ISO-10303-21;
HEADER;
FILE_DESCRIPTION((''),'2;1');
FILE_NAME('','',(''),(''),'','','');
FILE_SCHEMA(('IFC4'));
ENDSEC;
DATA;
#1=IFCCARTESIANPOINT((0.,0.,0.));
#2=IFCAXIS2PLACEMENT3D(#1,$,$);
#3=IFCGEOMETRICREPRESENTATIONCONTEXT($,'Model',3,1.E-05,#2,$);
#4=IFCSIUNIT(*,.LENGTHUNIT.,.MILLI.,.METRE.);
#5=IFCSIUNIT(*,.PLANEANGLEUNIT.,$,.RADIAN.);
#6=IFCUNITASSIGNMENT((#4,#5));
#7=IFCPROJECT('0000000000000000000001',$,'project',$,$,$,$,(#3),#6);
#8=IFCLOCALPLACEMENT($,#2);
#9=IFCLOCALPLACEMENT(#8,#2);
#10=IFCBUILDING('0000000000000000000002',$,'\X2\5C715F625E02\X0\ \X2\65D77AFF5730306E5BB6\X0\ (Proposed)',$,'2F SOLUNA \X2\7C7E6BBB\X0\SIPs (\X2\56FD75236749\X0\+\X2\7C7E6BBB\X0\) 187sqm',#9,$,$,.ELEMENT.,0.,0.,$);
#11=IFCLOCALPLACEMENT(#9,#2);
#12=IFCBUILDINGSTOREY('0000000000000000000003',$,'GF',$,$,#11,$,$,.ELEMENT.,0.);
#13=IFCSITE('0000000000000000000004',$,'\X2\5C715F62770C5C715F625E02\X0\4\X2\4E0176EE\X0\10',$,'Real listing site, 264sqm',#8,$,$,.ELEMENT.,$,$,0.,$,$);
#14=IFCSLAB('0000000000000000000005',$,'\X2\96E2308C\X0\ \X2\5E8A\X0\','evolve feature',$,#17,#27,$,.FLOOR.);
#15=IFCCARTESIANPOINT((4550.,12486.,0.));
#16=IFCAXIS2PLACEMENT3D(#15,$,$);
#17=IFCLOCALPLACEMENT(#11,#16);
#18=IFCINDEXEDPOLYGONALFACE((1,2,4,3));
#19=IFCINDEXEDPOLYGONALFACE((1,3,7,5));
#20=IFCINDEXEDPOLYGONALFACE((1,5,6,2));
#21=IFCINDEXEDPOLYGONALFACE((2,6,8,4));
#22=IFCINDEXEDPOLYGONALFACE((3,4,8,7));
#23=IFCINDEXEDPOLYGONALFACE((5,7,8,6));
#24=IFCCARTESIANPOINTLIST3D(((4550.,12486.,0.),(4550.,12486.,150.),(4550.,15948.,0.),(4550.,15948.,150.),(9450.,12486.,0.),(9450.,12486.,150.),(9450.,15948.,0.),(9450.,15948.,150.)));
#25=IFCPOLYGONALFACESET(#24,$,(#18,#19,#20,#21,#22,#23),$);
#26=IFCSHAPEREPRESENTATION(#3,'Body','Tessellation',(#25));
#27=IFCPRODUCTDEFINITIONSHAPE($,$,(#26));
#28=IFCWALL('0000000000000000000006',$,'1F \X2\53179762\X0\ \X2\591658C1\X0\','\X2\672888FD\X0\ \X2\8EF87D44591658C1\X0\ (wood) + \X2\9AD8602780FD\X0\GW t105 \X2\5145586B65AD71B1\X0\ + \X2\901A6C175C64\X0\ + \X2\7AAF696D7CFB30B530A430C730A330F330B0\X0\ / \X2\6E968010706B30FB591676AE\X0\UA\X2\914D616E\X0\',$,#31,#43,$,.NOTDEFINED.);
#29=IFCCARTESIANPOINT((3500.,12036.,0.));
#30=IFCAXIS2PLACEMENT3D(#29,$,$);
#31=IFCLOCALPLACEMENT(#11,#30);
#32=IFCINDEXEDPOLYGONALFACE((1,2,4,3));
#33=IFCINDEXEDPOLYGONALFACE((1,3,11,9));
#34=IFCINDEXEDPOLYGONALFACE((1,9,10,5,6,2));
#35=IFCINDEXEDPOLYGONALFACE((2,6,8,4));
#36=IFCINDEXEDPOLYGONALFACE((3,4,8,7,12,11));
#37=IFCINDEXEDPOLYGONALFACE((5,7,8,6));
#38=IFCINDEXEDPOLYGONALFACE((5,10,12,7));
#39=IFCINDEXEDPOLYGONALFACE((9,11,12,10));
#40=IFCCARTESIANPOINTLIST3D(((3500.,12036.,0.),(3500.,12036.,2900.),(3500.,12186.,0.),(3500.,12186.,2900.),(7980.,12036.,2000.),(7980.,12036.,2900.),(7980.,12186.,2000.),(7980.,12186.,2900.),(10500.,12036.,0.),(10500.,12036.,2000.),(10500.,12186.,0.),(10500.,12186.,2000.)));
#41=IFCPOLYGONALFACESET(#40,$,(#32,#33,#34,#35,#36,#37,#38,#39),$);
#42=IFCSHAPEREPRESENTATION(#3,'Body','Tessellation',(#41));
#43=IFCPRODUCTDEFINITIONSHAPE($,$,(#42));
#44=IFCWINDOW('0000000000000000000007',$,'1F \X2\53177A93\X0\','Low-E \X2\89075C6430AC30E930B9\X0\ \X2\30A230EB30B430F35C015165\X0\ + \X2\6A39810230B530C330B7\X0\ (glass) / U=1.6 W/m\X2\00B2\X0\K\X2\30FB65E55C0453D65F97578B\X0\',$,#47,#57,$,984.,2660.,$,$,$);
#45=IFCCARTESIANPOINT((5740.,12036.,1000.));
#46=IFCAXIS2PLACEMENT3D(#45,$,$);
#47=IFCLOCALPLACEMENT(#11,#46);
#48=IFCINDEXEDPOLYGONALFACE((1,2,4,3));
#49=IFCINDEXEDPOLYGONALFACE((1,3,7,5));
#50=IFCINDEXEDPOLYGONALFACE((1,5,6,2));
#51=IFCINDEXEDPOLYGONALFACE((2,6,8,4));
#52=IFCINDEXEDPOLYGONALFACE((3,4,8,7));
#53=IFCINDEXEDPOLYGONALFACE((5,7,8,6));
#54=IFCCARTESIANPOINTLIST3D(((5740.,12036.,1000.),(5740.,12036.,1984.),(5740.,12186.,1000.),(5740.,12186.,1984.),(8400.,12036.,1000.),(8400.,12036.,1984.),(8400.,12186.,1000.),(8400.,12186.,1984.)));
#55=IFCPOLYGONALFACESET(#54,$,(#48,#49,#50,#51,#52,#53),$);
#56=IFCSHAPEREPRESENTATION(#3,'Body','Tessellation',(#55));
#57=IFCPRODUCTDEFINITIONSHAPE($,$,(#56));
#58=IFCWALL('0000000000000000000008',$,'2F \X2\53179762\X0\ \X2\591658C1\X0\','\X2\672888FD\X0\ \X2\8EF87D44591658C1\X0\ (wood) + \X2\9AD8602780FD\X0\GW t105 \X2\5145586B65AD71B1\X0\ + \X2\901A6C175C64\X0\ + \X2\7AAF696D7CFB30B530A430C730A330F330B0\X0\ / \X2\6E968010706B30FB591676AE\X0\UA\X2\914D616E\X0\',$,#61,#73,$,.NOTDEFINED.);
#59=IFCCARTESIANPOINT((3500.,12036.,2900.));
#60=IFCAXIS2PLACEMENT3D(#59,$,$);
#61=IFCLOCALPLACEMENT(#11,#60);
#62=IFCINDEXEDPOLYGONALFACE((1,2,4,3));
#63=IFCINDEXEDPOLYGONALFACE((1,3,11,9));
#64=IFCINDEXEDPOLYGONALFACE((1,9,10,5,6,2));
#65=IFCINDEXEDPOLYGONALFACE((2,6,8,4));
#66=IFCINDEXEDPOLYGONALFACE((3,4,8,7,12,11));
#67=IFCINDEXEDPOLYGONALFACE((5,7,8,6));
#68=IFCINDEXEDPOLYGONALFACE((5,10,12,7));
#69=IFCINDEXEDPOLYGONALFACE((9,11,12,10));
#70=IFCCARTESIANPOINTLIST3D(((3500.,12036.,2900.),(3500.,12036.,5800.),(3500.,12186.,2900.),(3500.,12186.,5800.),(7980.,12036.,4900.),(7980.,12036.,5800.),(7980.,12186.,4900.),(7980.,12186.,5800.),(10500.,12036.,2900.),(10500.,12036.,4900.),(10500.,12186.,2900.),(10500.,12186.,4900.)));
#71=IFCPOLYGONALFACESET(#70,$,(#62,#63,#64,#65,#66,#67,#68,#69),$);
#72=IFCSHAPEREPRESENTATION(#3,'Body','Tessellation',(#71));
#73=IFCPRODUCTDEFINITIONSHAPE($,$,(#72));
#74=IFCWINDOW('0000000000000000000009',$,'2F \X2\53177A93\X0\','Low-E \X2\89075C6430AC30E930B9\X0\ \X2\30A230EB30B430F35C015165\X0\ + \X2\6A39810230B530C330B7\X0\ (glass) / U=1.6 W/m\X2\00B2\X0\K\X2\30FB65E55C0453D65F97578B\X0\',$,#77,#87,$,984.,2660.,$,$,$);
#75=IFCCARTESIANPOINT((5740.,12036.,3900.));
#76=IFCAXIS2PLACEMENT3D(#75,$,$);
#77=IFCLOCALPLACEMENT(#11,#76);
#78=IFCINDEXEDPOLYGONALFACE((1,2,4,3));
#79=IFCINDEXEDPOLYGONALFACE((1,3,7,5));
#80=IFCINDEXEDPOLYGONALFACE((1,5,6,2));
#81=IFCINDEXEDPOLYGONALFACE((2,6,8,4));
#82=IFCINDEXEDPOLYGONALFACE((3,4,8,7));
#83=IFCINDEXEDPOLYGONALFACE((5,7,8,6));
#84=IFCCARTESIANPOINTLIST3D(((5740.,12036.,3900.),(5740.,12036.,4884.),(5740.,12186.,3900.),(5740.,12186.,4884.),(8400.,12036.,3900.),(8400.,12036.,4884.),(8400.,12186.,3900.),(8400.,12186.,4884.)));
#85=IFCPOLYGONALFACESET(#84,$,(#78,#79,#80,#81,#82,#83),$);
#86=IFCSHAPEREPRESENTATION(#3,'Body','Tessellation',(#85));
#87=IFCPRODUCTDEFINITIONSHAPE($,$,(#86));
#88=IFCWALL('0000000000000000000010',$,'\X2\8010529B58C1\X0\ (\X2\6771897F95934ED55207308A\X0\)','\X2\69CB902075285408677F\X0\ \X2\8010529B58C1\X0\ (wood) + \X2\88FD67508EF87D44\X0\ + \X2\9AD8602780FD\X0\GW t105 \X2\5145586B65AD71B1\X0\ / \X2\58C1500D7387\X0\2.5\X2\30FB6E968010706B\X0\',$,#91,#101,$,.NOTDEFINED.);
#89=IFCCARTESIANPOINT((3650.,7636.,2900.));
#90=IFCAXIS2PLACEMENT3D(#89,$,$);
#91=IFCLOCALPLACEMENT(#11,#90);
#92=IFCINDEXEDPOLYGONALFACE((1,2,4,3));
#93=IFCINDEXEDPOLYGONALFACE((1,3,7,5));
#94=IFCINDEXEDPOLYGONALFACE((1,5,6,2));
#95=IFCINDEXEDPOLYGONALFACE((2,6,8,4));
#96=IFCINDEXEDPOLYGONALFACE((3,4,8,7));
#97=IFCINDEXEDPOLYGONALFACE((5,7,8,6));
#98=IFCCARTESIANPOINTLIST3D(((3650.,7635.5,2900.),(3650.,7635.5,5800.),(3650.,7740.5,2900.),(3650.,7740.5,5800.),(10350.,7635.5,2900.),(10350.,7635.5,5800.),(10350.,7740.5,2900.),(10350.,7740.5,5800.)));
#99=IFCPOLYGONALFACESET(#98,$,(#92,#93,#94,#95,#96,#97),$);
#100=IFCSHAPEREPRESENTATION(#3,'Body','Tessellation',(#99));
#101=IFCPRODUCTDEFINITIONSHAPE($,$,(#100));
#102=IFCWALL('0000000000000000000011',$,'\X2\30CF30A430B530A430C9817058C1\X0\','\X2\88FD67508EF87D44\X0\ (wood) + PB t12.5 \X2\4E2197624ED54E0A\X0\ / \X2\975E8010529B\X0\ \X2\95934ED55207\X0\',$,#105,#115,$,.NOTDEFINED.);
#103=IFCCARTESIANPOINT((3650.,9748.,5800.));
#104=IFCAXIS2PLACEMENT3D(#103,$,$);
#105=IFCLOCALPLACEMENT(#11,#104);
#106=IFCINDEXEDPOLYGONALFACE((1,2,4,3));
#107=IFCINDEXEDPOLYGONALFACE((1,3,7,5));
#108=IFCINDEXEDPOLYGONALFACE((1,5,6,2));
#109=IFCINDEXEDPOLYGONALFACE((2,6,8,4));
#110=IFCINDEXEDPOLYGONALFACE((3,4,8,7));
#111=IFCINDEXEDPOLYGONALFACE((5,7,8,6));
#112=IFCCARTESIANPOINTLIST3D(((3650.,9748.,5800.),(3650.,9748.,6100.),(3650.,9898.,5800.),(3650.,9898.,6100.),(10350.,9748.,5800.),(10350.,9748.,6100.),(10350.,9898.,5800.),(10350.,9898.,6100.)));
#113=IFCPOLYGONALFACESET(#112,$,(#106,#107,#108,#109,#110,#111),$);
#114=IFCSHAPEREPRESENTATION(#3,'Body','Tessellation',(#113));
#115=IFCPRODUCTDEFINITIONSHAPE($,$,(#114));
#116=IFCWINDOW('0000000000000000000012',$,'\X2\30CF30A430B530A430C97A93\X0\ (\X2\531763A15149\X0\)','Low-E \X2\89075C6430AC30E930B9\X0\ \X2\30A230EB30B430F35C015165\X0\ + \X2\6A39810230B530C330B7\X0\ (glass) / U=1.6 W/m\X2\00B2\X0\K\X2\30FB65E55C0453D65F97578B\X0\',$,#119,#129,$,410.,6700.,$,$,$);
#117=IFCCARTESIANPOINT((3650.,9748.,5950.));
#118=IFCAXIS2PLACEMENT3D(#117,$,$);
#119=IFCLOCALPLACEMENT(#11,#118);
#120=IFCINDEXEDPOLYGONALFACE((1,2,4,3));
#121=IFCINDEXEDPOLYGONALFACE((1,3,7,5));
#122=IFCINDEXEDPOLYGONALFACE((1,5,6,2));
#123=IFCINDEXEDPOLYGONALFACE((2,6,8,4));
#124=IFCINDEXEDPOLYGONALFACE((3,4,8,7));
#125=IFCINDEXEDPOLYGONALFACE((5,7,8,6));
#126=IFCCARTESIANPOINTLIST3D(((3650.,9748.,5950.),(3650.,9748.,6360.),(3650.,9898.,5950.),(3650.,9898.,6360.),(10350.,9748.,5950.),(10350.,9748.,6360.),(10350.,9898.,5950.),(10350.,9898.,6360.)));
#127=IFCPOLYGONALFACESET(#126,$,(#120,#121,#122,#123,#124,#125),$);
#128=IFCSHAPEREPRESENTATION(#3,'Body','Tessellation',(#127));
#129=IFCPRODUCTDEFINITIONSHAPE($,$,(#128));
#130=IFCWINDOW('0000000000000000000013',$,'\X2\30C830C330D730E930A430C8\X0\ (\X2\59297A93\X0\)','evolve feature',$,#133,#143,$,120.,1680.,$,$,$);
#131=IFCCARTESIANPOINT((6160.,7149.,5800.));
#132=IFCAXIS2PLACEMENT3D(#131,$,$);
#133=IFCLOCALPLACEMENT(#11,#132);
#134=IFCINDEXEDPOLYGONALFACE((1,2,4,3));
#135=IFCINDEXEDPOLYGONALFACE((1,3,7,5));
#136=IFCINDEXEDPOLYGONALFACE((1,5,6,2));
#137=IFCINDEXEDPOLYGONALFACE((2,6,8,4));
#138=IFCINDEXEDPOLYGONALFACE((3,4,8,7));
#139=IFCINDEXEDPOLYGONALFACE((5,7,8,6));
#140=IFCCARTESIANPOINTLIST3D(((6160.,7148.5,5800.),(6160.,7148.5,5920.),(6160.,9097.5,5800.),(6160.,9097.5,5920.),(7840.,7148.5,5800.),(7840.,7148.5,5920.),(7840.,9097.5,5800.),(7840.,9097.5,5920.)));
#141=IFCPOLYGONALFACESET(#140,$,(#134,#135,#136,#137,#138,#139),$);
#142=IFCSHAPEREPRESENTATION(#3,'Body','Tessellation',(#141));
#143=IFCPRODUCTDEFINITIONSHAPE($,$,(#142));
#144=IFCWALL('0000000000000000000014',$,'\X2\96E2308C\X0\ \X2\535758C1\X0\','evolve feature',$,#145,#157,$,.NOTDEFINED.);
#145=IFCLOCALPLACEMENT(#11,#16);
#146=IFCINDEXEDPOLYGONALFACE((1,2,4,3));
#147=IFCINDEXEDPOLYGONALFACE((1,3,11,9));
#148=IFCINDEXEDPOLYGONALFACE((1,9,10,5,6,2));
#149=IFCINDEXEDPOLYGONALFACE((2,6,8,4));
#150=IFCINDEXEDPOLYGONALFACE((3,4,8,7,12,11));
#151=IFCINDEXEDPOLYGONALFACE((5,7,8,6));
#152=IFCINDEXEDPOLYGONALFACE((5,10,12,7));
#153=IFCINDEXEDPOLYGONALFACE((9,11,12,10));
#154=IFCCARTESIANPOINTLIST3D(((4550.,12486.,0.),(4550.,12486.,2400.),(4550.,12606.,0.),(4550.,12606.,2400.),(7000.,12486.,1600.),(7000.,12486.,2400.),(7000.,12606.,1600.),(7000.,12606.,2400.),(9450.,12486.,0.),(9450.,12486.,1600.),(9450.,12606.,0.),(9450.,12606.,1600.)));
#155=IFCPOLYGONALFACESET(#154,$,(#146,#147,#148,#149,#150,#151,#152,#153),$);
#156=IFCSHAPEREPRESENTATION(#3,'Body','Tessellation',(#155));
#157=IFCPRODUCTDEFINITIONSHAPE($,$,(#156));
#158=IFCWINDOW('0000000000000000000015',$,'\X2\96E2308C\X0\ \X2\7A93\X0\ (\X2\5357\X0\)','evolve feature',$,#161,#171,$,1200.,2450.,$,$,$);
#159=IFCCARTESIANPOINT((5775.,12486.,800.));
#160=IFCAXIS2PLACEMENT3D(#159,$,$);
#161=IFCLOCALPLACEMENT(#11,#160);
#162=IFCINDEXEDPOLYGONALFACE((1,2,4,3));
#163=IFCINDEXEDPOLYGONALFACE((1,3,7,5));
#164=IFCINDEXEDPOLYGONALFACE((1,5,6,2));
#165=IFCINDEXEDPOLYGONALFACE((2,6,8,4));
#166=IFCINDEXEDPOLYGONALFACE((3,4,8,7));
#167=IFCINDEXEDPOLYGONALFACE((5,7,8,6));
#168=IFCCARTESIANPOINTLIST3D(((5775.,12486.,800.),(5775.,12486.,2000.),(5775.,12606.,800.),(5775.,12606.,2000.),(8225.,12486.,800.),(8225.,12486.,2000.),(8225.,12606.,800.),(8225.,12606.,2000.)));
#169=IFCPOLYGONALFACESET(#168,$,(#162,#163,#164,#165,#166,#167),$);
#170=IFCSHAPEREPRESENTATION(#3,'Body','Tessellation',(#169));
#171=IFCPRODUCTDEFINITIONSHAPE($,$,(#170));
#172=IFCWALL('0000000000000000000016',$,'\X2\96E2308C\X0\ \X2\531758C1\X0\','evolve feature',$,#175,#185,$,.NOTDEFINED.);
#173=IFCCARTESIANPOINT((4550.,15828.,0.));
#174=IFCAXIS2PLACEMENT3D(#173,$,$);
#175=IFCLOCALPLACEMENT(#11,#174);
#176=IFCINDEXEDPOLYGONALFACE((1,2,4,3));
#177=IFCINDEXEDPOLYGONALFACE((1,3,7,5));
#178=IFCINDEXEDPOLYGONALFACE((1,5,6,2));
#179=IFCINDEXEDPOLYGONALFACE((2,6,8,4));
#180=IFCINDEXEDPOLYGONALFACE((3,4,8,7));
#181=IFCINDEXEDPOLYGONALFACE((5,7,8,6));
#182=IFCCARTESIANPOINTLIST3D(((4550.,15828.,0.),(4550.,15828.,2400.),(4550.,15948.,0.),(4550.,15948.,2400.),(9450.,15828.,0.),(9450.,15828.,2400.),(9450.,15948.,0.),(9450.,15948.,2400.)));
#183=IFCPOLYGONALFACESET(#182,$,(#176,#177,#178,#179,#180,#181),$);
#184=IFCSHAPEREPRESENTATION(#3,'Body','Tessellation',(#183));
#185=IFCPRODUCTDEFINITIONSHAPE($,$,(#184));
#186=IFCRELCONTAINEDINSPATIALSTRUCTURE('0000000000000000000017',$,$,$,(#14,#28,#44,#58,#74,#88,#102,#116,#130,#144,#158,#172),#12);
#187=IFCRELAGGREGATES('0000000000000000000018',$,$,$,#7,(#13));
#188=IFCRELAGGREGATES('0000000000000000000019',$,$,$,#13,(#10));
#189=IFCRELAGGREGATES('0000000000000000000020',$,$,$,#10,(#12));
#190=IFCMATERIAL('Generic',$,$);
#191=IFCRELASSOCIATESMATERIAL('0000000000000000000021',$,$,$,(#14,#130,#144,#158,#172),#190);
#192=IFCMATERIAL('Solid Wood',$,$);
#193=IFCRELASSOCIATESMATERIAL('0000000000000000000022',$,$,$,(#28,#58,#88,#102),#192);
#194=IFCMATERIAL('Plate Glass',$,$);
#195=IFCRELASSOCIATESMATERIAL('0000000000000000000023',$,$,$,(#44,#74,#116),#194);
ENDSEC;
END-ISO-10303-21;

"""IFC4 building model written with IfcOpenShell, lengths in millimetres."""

from ifc_helpers import new_model, si_unit, frame, frame_2d, origin, place, context, project, spatial, rectangle, extrude, material, element, fill, save


model = new_model("IFC4")

# Units and contexts
model_context = context("Model", 3, precision=1e-05, world=origin())
ifc_project = project(units=[si_unit("LENGTHUNIT", "METRE", prefix="MILLI"), si_unit("PLANEANGLEUNIT", "RADIAN")], contexts=[model_context])

# Site, building, storey
site_placement = place(None, origin())
site = spatial("IfcSite", under=ifc_project, at=site_placement, Name="山形県山形市4丁目10", ObjectType="Real listing site, 264sqm", CompositionType="ELEMENT", RefElevation=0.0)
building_placement = place(site_placement, origin())
building = spatial("IfcBuilding", under=site, at=building_placement, Name="山形市 旗竿地の家 (Proposed)", ObjectType="2F SOLUNA 籾殻SIPs (国産杉+籾殻) 187sqm", CompositionType="ELEMENT", ElevationOfRefHeight=0.0, ElevationOfTerrain=0.0)
storey_placement = place(building_placement, origin())
storey = spatial("IfcBuildingStorey", under=building, at=storey_placement, Name="GF", CompositionType="ELEMENT", Elevation=0.0)

# Slab
ifc_material_1 = material(Name="Generic")
slab_placement = place(storey_placement, frame((4550.0, 12486.0, 0.0)))
element("IfcSlab", 1, at=slab_placement, inside=storey, material=ifc_material_1, Name="離れ 床", Description="evolve feature", PredefinedType="FLOOR", context=model_context, shape_type="SweptSolid", body=[
    extrude(rectangle(XDim=4900.0, YDim=3462.0, at=frame_2d((2450.0, 1731.0))), frame((4550.0, 12486.0, 0.0)), (0.0, 0.0, 1.0), 150.0),
])

# Wall, opening, window
ifc_material_2 = material(Name="Solid Wood")
wall_1_placement = place(storey_placement, frame((3500.0, 12036.0, 0.0)))
wall_1 = element("IfcWall", 2, at=wall_1_placement, inside=storey, material=ifc_material_2, Name="1F 北面 外壁", Description="木製 軸組外壁 (wood) + 高性能GW t105 充填断熱 + 通気層 + 窯業系サイディング / 準耐火・外皮UA配慮", PredefinedType="NOTDEFINED", context=model_context, shape_type="SweptSolid", body=[
    extrude(rectangle(XDim=7000.0, YDim=150.0, at=frame_2d((3500.0, 75.0))), frame((3500.0, 12036.0, 0.0)), (0.0, 0.0, 1.0), 2900.0),
])
opening_1_placement = place(storey_placement, frame((5740.0, 12036.0, 1000.0)))
opening_1 = element("IfcOpeningElement", 3, at=opening_1_placement, cuts=wall_1, PredefinedType="NOTDEFINED", context=model_context, shape_type="SweptSolid", body=[
    extrude(rectangle(XDim=2660.0, YDim=150.0, at=frame_2d((1330.0, 75.0))), frame((5740.0, 12036.0, 1000.0)), (0.0, 0.0, 1.0), 984.0),
])
ifc_material_3 = material(Name="Plate Glass")
window_1_placement = place(storey_placement, frame((5740.0, 12036.0, 1000.0)))
window_1 = element("IfcWindow", 4, at=window_1_placement, inside=storey, material=ifc_material_3, Name="1F 北窓", Description="Low-E 複層ガラス アルゴン封入 + 樹脂サッシ (glass) / U=1.6 W/m²K・日射取得型", OverallHeight=984.0, OverallWidth=2660.0, context=model_context, shape_type="SweptSolid", body=[
    extrude(rectangle(XDim=2660.0, YDim=150.0, at=frame_2d((1330.0, 75.0))), frame((5740.0, 12036.0, 1000.0)), (0.0, 0.0, 1.0), 984.0),
])
fill(opening_1, window_1)

# Wall, opening, window
wall_2_placement = place(storey_placement, frame((3500.0, 12036.0, 2900.0)))
wall_2 = element("IfcWall", 5, at=wall_2_placement, inside=storey, material=ifc_material_2, Name="2F 北面 外壁", Description="木製 軸組外壁 (wood) + 高性能GW t105 充填断熱 + 通気層 + 窯業系サイディング / 準耐火・外皮UA配慮", PredefinedType="NOTDEFINED", context=model_context, shape_type="SweptSolid", body=[
    extrude(rectangle(XDim=7000.0, YDim=150.0, at=frame_2d((3500.0, 75.0))), frame((3500.0, 12036.0, 2900.0)), (0.0, 0.0, 1.0), 2900.0),
])
opening_2_placement = place(storey_placement, frame((5740.0, 12036.0, 3900.0)))
opening_2 = element("IfcOpeningElement", 6, at=opening_2_placement, cuts=wall_2, PredefinedType="NOTDEFINED", context=model_context, shape_type="SweptSolid", body=[
    extrude(rectangle(XDim=2660.0, YDim=150.0, at=frame_2d((1330.0, 75.0))), frame((5740.0, 12036.0, 3900.0)), (0.0, 0.0, 1.0), 984.0),
])
window_2_placement = place(storey_placement, frame((5740.0, 12036.0, 3900.0)))
window_2 = element("IfcWindow", 7, at=window_2_placement, inside=storey, material=ifc_material_3, Name="2F 北窓", Description="Low-E 複層ガラス アルゴン封入 + 樹脂サッシ (glass) / U=1.6 W/m²K・日射取得型", OverallHeight=984.0, OverallWidth=2660.0, context=model_context, shape_type="SweptSolid", body=[
    extrude(rectangle(XDim=2660.0, YDim=150.0, at=frame_2d((1330.0, 75.0))), frame((5740.0, 12036.0, 3900.0)), (0.0, 0.0, 1.0), 984.0),
])
fill(opening_2, window_2)

# Wall
wall_3_placement = place(storey_placement, frame((3650.0, 7636.0, 2900.0)))
element("IfcWall", 8, at=wall_3_placement, inside=storey, material=ifc_material_2, Name="耐力壁 (東西間仕切り)", Description="構造用合板 耐力壁 (wood) + 製材軸組 + 高性能GW t105 充填断熱 / 壁倍率2.5・準耐火", PredefinedType="NOTDEFINED", context=model_context, shape_type="SweptSolid", body=[
    extrude(rectangle(XDim=6700.0, YDim=105.0, at=frame_2d((3350.0, 52.0))), frame((3650.0, 7636.0, 2900.0)), (0.0, 0.0, 1.0), 2900.0),
])

# Wall, opening, window
wall_4_placement = place(storey_placement, frame((3650.0, 9748.0, 5800.0)))
wall_4 = element("IfcWall", 9, at=wall_4_placement, inside=storey, material=ifc_material_2, Name="ハイサイド腰壁", Description="製材軸組 (wood) + PB t12.5 両面仕上 / 非耐力 間仕切", PredefinedType="NOTDEFINED", context=model_context, shape_type="SweptSolid", body=[
    extrude(rectangle(XDim=6700.0, YDim=150.0, at=frame_2d((3350.0, 75.0))), frame((3650.0, 9748.0, 5800.0)), (0.0, 0.0, 1.0), 700.0),
])
opening_3_placement = place(storey_placement, frame((3650.0, 9748.0, 5950.0)))
opening_3 = element("IfcOpeningElement", 10, at=opening_3_placement, cuts=wall_4, PredefinedType="NOTDEFINED", context=model_context, shape_type="SweptSolid", body=[
    extrude(rectangle(XDim=6700.0, YDim=150.0, at=frame_2d((3350.0, 75.0))), frame((3650.0, 9748.0, 5950.0)), (0.0, 0.0, 1.0), 410.0),
])
window_3_placement = place(storey_placement, frame((3650.0, 9748.0, 5950.0)))
window_3 = element("IfcWindow", 11, at=window_3_placement, inside=storey, material=ifc_material_3, Name="ハイサイド窓 (北採光)", Description="Low-E 複層ガラス アルゴン封入 + 樹脂サッシ (glass) / U=1.6 W/m²K・日射取得型", OverallHeight=410.0, OverallWidth=6700.0, context=model_context, shape_type="SweptSolid", body=[
    extrude(rectangle(XDim=6700.0, YDim=150.0, at=frame_2d((3350.0, 75.0))), frame((3650.0, 9748.0, 5950.0)), (0.0, 0.0, 1.0), 410.0),
])
fill(opening_3, window_3)

# Window
window_4_placement = place(storey_placement, frame((6160.0, 7149.0, 5800.0)))
element("IfcWindow", 12, at=window_4_placement, inside=storey, material=ifc_material_1, Name="トップライト (天窓)", Description="evolve feature", OverallHeight=120.0, OverallWidth=1680.0, context=model_context, shape_type="SweptSolid", body=[
    extrude(rectangle(XDim=1680.0, YDim=1949.0, at=frame_2d((840.0, 974.0))), frame((6160.0, 7149.0, 5800.0)), (0.0, 0.0, 1.0), 120.0),
])

# Wall, opening, window
wall_5_placement = place(storey_placement, frame((4550.0, 12486.0, 0.0)))
wall_5 = element("IfcWall", 13, at=wall_5_placement, inside=storey, material=ifc_material_1, Name="離れ 南壁", Description="evolve feature", PredefinedType="NOTDEFINED", context=model_context, shape_type="SweptSolid", body=[
    extrude(rectangle(XDim=4900.0, YDim=120.0, at=frame_2d((2450.0, 60.0))), frame((4550.0, 12486.0, 0.0)), (0.0, 0.0, 1.0), 2400.0),
])
opening_4_placement = place(storey_placement, frame((5775.0, 12486.0, 800.0)))
opening_4 = element("IfcOpeningElement", 14, at=opening_4_placement, cuts=wall_5, PredefinedType="NOTDEFINED", context=model_context, shape_type="SweptSolid", body=[
    extrude(rectangle(XDim=2450.0, YDim=120.0, at=frame_2d((1225.0, 60.0))), frame((5775.0, 12486.0, 800.0)), (0.0, 0.0, 1.0), 1200.0),
])
window_5_placement = place(storey_placement, frame((5775.0, 12486.0, 800.0)))
window_5 = element("IfcWindow", 15, at=window_5_placement, inside=storey, material=ifc_material_1, Name="離れ 窓 (南)", Description="evolve feature", OverallHeight=1200.0, OverallWidth=2450.0, context=model_context, shape_type="SweptSolid", body=[
    extrude(rectangle(XDim=2450.0, YDim=120.0, at=frame_2d((1225.0, 60.0))), frame((5775.0, 12486.0, 800.0)), (0.0, 0.0, 1.0), 1200.0),
])
fill(opening_4, window_5)

# Wall
wall_6_placement = place(storey_placement, frame((4550.0, 15828.0, 0.0)))
element("IfcWall", 16, at=wall_6_placement, inside=storey, material=ifc_material_1, Name="離れ 北壁", Description="evolve feature", PredefinedType="NOTDEFINED", context=model_context, shape_type="SweptSolid", body=[
    extrude(rectangle(XDim=4900.0, YDim=120.0, at=frame_2d((2450.0, 60.0))), frame((4550.0, 15828.0, 0.0)), (0.0, 0.0, 1.0), 2400.0),
])

save(model, "model.ifc")
